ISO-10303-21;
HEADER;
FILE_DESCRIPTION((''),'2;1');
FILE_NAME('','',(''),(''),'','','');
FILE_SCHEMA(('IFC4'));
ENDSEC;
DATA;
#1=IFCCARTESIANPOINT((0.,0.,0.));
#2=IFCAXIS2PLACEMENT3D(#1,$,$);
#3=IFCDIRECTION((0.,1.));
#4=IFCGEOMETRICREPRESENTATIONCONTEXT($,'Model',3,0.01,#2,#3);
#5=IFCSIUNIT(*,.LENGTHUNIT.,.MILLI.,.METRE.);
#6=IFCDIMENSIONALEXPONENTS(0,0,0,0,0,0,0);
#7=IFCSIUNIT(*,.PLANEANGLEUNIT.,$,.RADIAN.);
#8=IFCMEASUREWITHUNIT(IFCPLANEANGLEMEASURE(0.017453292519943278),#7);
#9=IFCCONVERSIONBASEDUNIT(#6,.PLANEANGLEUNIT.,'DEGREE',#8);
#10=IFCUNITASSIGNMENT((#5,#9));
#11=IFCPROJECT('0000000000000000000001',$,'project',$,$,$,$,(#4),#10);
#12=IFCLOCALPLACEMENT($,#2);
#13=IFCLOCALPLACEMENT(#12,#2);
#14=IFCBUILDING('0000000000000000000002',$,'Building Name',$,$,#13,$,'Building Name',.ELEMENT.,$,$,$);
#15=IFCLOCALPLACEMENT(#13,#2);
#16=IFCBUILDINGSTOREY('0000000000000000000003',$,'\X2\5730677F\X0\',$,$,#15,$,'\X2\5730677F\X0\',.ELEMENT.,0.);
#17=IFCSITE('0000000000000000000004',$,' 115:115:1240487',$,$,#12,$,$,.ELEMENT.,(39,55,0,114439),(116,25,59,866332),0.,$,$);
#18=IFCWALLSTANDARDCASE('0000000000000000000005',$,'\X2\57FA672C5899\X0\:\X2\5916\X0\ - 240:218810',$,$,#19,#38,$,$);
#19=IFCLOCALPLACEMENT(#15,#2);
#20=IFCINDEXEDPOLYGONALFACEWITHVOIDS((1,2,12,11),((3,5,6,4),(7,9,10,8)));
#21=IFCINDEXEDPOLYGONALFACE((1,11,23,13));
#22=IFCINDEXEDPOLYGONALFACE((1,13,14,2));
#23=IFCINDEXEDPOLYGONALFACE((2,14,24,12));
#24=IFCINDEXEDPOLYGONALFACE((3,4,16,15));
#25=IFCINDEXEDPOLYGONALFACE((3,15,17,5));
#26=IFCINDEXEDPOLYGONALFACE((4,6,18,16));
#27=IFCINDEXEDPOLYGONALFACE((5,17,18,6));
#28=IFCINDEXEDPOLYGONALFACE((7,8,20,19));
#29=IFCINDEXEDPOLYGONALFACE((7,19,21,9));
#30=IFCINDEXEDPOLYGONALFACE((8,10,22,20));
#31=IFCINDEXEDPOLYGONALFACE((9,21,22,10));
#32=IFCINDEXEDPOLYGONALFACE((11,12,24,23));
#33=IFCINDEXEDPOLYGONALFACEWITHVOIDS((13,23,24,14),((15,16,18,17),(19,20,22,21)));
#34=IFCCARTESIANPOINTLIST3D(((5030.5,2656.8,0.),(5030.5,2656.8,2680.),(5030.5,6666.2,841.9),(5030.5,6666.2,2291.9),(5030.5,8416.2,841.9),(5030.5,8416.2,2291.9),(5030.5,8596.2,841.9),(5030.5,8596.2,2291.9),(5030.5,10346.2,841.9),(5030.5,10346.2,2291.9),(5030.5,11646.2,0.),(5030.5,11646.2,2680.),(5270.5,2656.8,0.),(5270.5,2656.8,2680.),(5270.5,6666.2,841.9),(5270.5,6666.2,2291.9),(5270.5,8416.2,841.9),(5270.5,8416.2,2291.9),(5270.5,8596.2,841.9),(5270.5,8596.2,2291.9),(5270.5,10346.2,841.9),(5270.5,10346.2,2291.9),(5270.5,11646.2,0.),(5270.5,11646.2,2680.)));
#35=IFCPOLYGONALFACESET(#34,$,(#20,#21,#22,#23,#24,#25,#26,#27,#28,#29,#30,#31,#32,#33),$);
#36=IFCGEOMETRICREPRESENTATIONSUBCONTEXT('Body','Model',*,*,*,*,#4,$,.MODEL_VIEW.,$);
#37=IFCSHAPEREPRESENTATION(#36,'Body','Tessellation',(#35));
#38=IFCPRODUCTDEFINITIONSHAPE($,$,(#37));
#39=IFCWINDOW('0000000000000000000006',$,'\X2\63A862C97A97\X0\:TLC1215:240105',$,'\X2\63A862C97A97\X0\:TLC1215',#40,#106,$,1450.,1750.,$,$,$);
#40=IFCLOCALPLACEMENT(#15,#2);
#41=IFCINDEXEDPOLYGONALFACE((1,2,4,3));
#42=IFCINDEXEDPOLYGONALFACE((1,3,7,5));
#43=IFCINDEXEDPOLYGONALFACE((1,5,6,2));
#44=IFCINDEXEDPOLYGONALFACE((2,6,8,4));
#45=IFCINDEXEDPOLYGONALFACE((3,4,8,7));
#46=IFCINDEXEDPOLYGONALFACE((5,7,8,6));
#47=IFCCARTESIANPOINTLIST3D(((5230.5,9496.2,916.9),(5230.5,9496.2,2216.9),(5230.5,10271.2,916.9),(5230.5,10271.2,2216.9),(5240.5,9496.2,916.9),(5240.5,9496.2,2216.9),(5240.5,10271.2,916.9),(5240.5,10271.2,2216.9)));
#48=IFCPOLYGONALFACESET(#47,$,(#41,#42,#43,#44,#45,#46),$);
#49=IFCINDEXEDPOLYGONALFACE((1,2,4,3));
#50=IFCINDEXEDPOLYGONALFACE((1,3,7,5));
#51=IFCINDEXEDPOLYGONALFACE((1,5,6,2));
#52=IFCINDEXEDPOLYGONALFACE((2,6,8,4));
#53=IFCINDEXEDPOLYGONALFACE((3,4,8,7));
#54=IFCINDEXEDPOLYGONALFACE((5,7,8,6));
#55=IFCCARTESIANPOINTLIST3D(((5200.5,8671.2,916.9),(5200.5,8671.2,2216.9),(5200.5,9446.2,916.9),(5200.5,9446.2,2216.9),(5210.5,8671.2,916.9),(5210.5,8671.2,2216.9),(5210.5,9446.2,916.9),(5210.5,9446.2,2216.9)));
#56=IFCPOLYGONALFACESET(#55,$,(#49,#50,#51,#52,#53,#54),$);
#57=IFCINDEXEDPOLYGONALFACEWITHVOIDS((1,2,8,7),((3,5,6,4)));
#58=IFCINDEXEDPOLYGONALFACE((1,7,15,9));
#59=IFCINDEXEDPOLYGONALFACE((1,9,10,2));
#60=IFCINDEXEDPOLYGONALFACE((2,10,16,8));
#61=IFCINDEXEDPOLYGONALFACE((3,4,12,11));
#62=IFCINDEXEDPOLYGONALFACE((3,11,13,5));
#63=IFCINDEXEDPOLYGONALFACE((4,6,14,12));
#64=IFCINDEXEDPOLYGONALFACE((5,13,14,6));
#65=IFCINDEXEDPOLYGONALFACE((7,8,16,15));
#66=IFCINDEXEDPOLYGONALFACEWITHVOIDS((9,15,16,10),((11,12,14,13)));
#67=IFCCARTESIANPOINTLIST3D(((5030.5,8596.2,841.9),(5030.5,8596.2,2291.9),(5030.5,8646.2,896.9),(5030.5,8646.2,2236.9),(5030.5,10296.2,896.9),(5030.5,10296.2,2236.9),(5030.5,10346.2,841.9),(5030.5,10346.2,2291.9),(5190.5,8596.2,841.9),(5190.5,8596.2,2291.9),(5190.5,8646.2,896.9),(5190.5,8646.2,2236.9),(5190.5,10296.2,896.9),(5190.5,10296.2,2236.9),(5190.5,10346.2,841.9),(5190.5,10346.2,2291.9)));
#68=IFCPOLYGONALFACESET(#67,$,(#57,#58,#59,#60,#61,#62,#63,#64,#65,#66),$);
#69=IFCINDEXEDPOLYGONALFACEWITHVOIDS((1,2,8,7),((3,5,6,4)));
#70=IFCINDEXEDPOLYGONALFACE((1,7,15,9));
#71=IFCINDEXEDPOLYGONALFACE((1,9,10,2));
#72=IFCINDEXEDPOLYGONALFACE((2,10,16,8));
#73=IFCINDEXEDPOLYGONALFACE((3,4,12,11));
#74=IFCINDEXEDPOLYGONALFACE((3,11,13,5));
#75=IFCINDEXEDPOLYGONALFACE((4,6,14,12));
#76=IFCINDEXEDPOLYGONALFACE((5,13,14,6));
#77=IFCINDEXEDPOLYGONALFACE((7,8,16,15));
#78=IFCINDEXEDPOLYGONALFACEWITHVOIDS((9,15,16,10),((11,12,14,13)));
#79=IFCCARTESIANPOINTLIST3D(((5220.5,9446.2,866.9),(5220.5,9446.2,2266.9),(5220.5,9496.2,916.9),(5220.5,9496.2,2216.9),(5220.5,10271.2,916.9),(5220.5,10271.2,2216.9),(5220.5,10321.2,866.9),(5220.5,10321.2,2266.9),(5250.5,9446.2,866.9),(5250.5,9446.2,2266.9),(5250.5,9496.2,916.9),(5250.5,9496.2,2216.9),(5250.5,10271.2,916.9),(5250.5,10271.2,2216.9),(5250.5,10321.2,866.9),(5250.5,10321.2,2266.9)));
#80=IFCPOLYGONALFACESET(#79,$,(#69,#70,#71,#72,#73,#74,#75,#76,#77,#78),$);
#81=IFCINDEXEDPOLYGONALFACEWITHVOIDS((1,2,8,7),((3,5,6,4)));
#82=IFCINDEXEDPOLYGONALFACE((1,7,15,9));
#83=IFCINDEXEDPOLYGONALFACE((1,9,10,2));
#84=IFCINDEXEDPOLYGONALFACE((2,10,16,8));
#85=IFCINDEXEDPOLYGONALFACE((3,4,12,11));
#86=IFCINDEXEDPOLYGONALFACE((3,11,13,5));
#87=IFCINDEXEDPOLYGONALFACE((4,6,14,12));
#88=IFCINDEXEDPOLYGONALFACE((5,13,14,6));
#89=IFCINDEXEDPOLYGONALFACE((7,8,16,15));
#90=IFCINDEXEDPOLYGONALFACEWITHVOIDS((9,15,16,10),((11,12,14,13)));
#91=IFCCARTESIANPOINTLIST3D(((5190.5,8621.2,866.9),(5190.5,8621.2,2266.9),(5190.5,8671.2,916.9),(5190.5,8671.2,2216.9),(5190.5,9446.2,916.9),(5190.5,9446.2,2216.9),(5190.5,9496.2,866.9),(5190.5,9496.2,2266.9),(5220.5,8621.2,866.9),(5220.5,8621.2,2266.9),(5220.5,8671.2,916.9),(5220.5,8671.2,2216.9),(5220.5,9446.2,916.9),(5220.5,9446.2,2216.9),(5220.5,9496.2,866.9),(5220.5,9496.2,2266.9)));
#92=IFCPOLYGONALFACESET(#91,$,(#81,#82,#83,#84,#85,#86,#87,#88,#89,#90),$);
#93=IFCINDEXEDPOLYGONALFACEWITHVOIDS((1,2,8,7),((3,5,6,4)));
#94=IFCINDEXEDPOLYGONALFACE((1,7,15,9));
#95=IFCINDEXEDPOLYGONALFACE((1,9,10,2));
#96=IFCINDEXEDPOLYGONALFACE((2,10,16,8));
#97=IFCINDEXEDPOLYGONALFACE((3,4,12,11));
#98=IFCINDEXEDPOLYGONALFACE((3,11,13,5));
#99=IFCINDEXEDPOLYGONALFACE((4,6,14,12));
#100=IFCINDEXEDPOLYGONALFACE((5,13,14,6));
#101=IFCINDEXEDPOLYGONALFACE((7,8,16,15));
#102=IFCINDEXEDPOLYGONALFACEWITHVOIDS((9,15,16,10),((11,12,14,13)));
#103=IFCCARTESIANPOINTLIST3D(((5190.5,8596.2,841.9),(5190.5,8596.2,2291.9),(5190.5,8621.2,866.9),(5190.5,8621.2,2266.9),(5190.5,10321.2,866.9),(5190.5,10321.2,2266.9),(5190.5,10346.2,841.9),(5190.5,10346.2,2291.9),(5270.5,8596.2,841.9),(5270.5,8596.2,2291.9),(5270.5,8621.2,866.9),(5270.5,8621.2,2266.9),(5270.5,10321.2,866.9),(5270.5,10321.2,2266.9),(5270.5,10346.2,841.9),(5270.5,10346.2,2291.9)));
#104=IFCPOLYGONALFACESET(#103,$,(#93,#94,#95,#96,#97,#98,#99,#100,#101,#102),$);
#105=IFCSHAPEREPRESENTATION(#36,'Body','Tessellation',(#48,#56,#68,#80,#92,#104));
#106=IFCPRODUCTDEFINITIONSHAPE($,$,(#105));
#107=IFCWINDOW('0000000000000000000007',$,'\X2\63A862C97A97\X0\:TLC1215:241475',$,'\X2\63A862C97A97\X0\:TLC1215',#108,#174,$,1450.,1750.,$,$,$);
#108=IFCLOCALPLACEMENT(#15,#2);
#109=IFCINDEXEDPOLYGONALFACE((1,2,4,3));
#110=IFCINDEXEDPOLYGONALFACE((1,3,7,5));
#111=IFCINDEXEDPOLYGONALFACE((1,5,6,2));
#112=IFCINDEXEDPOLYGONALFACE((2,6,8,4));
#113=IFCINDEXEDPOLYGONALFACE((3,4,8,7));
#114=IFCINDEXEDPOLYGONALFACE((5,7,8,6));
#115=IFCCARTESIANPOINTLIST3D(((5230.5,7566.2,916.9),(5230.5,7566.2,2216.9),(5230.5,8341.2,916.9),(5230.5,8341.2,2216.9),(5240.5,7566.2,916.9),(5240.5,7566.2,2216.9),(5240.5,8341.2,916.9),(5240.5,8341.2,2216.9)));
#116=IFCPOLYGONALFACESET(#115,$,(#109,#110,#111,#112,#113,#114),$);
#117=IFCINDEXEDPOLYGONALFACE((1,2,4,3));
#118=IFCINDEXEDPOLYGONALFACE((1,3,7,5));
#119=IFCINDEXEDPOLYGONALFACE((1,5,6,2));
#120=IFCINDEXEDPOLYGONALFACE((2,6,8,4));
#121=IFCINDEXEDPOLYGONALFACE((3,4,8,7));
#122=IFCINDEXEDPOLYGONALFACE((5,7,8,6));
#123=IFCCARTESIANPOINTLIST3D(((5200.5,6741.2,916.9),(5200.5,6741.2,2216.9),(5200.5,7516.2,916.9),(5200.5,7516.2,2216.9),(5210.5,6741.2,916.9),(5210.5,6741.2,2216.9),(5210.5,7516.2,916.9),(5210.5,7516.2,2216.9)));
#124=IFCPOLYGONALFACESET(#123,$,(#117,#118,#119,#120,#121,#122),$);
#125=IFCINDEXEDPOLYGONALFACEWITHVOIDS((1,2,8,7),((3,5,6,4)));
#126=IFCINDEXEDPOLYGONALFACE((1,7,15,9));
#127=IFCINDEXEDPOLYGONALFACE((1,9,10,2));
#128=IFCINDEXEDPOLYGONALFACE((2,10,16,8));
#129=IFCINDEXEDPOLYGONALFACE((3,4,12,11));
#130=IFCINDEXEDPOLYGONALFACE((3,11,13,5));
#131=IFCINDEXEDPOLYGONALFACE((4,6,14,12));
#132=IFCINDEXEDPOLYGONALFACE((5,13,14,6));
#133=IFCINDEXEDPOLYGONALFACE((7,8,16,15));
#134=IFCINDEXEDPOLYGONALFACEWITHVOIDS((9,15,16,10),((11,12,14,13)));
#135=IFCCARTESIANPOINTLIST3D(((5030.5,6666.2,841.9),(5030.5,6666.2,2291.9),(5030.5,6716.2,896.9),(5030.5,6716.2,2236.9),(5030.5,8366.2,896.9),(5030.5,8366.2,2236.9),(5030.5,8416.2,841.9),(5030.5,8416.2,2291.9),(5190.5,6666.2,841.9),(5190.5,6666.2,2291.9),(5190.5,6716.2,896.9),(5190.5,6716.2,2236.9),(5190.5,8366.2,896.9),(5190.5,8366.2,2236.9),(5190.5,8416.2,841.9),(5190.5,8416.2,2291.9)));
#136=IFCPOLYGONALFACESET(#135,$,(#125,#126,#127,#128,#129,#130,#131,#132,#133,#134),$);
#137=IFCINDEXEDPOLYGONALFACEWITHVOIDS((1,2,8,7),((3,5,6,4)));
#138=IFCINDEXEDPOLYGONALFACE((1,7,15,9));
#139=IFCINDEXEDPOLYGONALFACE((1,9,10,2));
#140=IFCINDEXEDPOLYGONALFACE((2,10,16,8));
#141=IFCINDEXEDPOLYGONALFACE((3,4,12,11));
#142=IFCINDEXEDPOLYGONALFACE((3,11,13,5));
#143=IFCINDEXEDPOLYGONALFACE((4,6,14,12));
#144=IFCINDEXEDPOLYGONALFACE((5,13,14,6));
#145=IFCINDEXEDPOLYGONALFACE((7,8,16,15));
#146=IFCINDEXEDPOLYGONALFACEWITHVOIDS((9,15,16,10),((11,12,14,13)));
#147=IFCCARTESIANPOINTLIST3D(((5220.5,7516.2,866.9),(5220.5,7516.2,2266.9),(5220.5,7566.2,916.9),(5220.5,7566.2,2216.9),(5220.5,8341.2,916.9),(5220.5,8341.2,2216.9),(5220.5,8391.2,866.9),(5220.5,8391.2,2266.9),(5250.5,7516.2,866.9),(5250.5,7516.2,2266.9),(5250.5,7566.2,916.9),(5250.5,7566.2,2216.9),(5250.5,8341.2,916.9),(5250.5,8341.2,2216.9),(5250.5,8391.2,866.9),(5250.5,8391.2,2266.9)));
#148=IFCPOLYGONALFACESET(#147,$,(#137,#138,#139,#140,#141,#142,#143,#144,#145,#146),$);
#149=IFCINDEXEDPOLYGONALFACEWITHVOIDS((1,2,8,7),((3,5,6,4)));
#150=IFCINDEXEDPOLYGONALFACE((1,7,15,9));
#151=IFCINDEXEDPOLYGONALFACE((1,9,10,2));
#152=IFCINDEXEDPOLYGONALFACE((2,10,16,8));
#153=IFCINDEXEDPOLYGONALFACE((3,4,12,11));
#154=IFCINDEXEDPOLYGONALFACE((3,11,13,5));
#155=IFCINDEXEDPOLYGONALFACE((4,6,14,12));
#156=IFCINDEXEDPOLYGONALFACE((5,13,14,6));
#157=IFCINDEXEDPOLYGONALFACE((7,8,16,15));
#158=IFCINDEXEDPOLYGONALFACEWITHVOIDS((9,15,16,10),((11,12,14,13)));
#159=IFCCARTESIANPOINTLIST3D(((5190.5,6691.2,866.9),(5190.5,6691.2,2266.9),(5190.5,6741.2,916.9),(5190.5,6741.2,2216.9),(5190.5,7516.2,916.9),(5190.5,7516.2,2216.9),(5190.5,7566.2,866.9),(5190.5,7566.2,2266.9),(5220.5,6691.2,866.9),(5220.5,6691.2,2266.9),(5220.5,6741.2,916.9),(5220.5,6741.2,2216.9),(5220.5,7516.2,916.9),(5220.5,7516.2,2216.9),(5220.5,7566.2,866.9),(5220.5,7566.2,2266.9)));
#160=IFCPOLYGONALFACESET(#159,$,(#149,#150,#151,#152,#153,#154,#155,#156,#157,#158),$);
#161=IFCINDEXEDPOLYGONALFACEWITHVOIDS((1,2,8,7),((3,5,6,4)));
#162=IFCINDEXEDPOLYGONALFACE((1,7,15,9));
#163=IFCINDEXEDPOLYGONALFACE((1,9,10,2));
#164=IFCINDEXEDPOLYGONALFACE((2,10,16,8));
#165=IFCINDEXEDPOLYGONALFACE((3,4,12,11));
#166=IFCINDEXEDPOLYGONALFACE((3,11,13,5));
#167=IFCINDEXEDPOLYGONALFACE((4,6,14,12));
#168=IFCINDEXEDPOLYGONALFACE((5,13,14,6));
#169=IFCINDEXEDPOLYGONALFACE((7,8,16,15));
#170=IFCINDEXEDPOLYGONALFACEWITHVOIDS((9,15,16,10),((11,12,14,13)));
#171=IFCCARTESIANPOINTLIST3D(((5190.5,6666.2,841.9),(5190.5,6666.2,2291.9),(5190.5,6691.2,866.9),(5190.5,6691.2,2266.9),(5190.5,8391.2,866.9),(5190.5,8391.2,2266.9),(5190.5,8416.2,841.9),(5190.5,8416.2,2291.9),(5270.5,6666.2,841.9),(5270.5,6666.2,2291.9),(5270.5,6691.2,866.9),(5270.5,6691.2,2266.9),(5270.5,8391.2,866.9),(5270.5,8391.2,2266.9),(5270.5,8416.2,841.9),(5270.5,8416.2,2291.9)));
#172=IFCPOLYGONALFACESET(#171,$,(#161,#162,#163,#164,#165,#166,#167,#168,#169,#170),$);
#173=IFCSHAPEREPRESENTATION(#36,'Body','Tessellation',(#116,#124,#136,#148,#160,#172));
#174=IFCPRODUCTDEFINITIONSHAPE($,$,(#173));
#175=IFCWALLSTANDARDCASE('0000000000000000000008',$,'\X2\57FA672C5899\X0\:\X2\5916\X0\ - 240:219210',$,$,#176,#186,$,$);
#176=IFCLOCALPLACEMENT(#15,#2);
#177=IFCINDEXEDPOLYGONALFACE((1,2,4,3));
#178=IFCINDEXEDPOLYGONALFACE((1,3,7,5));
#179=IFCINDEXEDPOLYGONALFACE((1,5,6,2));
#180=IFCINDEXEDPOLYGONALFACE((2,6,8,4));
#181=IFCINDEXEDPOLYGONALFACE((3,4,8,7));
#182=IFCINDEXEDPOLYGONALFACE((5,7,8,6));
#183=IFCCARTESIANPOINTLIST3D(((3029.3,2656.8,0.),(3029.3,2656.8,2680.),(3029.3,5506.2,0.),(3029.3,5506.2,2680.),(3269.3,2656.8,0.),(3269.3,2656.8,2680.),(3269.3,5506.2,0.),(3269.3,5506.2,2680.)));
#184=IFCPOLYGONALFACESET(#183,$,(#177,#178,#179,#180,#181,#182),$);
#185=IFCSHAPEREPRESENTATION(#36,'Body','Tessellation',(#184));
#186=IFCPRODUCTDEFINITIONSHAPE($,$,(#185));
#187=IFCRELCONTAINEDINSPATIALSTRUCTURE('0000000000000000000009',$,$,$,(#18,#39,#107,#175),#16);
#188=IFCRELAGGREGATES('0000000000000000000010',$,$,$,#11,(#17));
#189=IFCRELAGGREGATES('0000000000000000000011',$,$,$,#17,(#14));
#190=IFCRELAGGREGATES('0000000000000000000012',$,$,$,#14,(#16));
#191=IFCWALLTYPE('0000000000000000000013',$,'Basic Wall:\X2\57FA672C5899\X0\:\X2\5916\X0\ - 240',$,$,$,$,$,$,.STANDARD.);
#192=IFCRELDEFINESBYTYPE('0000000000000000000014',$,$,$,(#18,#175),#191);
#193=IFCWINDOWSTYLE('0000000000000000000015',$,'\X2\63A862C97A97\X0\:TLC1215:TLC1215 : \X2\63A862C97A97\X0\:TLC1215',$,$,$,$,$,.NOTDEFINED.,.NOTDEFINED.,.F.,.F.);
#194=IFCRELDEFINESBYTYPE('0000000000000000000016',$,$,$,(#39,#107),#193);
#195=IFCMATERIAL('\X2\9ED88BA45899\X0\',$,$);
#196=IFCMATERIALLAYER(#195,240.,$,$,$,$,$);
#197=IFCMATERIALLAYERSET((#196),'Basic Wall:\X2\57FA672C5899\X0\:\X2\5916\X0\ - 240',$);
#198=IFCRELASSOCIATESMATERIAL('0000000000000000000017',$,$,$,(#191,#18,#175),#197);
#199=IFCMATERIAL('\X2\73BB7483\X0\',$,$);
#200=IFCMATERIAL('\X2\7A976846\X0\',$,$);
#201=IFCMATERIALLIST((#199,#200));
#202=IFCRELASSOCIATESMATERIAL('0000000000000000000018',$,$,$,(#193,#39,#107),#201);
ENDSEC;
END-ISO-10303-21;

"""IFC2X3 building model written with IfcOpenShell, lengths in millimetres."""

from ifc_helpers import new_model, entity, si_unit, converted_unit, direction, frame, frame_2d, origin, origin_2d_with_axis, place, context, subcontext, project, spatial, polyline, rectangle, outline, extrude, source, transform, mapped, material, material_list, layer, layer_set, layer_usage, type_object, type_shapes, element, fill, save


model = new_model("IFC2X3")

# Units and contexts
model_context = context("Model", 3, precision=0.01, world=origin(), true_north=direction((0.0, 1.0)))
body_context = subcontext(model_context, "Body", "Model", "MODEL_VIEW")
ifc_project = project(units=[si_unit("LENGTHUNIT", "METRE", prefix="MILLI"), converted_unit("PLANEANGLEUNIT", "DEGREE", entity("IfcPlaneAngleMeasure", 0.017453292519943278), si_unit("PLANEANGLEUNIT", "RADIAN"), dimensions=[0, 0, 0, 0, 0, 0, 0])], contexts=[model_context])

# Site, building, storey
site_placement = place(None, origin())
site = spatial("IfcSite", under=ifc_project, at=site_placement, Name=" 115:115:1240487", CompositionType="ELEMENT", RefLatitude=(39, 55, 0, 114439), RefLongitude=(116, 25, 59, 866332), RefElevation=0.0)
building_placement = place(site_placement, origin())
building = spatial("IfcBuilding", under=site, at=building_placement, Name="Building Name", LongName="Building Name", CompositionType="ELEMENT")
storey_placement = place(building_placement, origin())
storey = spatial("IfcBuildingStorey", under=building, at=storey_placement, Name="地板", LongName="地板", CompositionType="ELEMENT", Elevation=0.0)

# Wall, openings, windows
ifc_material_1 = material(Name="默认墙")
ifc_layer_1 = layer(ifc_material_1, 240.0)
ifc_layer_set_1 = layer_set([ifc_layer_1], Name="Basic Wall:基本墙:外 - 240")
wall_type_1 = type_object("IfcWallType", Name="Basic Wall:基本墙:外 - 240", PredefinedType="STANDARD", material=ifc_layer_set_1)
ifc_material_2 = material(Name="玻璃")
ifc_material_3 = material(Name="窗框")
ifc_material_list_1 = material_list([ifc_material_2, ifc_material_3])
ifc_layer_usage_1 = layer_usage(ifc_layer_set_1, "AXIS2", "NEGATIVE", 120.0)
wall_1_placement = place(storey_placement, frame((5150.5, 11646.2, 0.0), z_axis=(0.0, 0.0, 1.0), x_axis=(0.0, -1.0, 0.0)))
wall_1 = element("IfcWallStandardCase", 1, at=wall_1_placement, inside=storey, type_object=wall_type_1, material=ifc_layer_usage_1, Name="基本墙:外 - 240:218810", context=body_context, shape_type="SweptSolid", body=[
    extrude(rectangle(XDim=8989.4, YDim=240.0, at=frame_2d((4494.7, 0.0), x_axis=(-1.0, 0.0))), origin(), (0.0, 0.0, 1.0), 2680.0),
])
opening_1_placement = place(wall_1_placement, frame((11646.2, -5150.5, 0.0), z_axis=(0.0, 0.0, 1.0), x_axis=(0.0, 1.0, 0.0)))
opening_1 = element("IfcOpeningElement", 2, at=opening_1_placement, cuts=wall_1, ObjectType="Opening", context=body_context, shape_type="SweptSolid", body=[
    extrude(rectangle(XDim=1450.0, YDim=1750.0, at=frame_2d((0.0, 0.0), x_axis=(0.0, 1.0))), frame((5028.1, 9471.2, 1566.9), z_axis=(1.0, 0.0, 0.0), x_axis=(0.0, 1.0, 0.0)), (0.0, 0.0, 1.0), 244.8),
])
opening_2_placement = place(wall_1_placement, frame((11646.2, -5150.5, 0.0), z_axis=(0.0, 0.0, 1.0), x_axis=(0.0, 1.0, 0.0)))
opening_2 = element("IfcOpeningElement", 3, at=opening_2_placement, cuts=wall_1, ObjectType="Opening", context=body_context, shape_type="SweptSolid", body=[
    extrude(rectangle(XDim=1450.0, YDim=1750.0, at=frame_2d((0.0, 0.0), x_axis=(0.0, 1.0))), frame((5028.1, 7541.2, 1566.9), z_axis=(1.0, 0.0, 0.0), x_axis=(0.0, 1.0, 0.0)), (0.0, 0.0, 1.0), 244.8),
])
window_style_1 = type_object("IfcWindowStyle", Name="推拉窗:TLC1215:TLC1215 : 推拉窗:TLC1215", ConstructionType="NOTDEFINED", OperationType="NOTDEFINED", ParameterTakesPrecedence=False, Sizeable=False, material=ifc_material_list_1)
shared_shape_1 = source(origin(), body_context, "Body", "SweptSolid", [
    extrude(rectangle(XDim=775.0, YDim=10.0, at=origin_2d_with_axis()), frame((462.5, -37.4, 75.0)), (0.0, 0.0, 1.0), 1300.0),
    extrude(rectangle(XDim=775.0, YDim=10.0, at=frame_2d((0.0, 0.0), x_axis=(1.0, 0.0))), frame((1287.5, -67.4, 75.0)), (0.0, 0.0, 1.0), 1300.0),
    extrude(outline(polyline([(-725.0, -875.0), (725.0, -875.0), (725.0, 875.0), (-725.0, 875.0), (-725.0, -875.0)]), holes=[polyline([(-670.0, 825.0), (670.0, 825.0), (670.0, -825.0), (-670.0, -825.0), (-670.0, 825.0)])]), frame((875.0, -242.4, 725.0), z_axis=(0.0, 1.0, 0.0), x_axis=(0.0, 0.0, -1.0)), (0.0, 0.0, 1.0), 160.0),
    extrude(outline(polyline([(-700.0, -437.5), (700.0, -437.5), (700.0, 437.5), (-700.0, 437.5), (-700.0, -437.5)]), holes=[polyline([(650.0, 387.5), (650.0, -387.5), (-650.0, -387.5), (-650.0, 387.5), (650.0, 387.5)])]), frame((462.5, -52.4, 725.0), z_axis=(0.0, 1.0, 0.0), x_axis=(0.0, 0.0, 1.0)), (0.0, 0.0, 1.0), 30.0),
    extrude(outline(polyline([(-700.0, -437.5), (700.0, -437.5), (700.0, 437.5), (-700.0, 437.5), (-700.0, -437.5)]), holes=[polyline([(650.0, 387.5), (650.0, -387.5), (-650.0, -387.5), (-650.0, 387.5), (650.0, 387.5)])]), frame((1287.5, -82.4, 725.0), z_axis=(0.0, 1.0, 0.0), x_axis=(0.0, 0.0, -1.0)), (0.0, 0.0, 1.0), 30.0),
    extrude(outline(polyline([(-725.0, -875.0), (725.0, -875.0), (725.0, 875.0), (-725.0, 875.0), (-725.0, -875.0)]), holes=[polyline([(700.0, -850.0), (-700.0, -850.0), (-700.0, 850.0), (700.0, 850.0), (700.0, -850.0)])]), frame((875.0, -82.4, 725.0), z_axis=(0.0, 1.0, 0.0), x_axis=(0.0, 0.0, -1.0)), (0.0, 0.0, 1.0), 80.0),
])
type_shapes(window_style_1, [shared_shape_1])
window_1_placement = place(opening_1_placement, frame((5272.9, 10346.2, 841.9), z_axis=(0.0, 0.0, 1.0), x_axis=(0.0, -1.0, 0.0)))
window_1 = element("IfcWindow", 4, at=window_1_placement, inside=storey, type_object=window_style_1, material=ifc_material_list_1, Name="推拉窗:TLC1215:240105", ObjectType="推拉窗:TLC1215", OverallHeight=1450.0, OverallWidth=1750.0, context=body_context, shape_type="MappedRepresentation", body=[
    mapped(shared_shape_1, transform((0.0, 0.0, 0.0), scale=1.0)),
])
fill(opening_1, window_1)
window_2_placement = place(opening_2_placement, frame((5272.9, 8416.2, 841.9), z_axis=(0.0, 0.0, 1.0), x_axis=(0.0, -1.0, 0.0)))
window_2 = element("IfcWindow", 5, at=window_2_placement, inside=storey, type_object=window_style_1, material=ifc_material_list_1, Name="推拉窗:TLC1215:241475", ObjectType="推拉窗:TLC1215", OverallHeight=1450.0, OverallWidth=1750.0, context=body_context, shape_type="MappedRepresentation", body=[
    mapped(shared_shape_1, transform((0.0, 0.0, 0.0), scale=1.0)),
])
fill(opening_2, window_2)

# Wall
ifc_layer_usage_2 = layer_usage(ifc_layer_set_1, "AXIS2", "NEGATIVE", 120.0)
wall_2_placement = place(storey_placement, frame((3149.3, 5506.2, 0.0), z_axis=(0.0, 0.0, 1.0), x_axis=(0.0, -1.0, 0.0)))
element("IfcWallStandardCase", 6, at=wall_2_placement, inside=storey, type_object=wall_type_1, material=ifc_layer_usage_2, Name="基本墙:外 - 240:219210", context=body_context, shape_type="SweptSolid", body=[
    extrude(rectangle(XDim=2849.4, YDim=240.0, at=frame_2d((1424.7, 0.0), x_axis=(-1.0, 0.0))), origin(), (0.0, 0.0, 1.0), 2680.0),
])

save(model, "model.ifc")
